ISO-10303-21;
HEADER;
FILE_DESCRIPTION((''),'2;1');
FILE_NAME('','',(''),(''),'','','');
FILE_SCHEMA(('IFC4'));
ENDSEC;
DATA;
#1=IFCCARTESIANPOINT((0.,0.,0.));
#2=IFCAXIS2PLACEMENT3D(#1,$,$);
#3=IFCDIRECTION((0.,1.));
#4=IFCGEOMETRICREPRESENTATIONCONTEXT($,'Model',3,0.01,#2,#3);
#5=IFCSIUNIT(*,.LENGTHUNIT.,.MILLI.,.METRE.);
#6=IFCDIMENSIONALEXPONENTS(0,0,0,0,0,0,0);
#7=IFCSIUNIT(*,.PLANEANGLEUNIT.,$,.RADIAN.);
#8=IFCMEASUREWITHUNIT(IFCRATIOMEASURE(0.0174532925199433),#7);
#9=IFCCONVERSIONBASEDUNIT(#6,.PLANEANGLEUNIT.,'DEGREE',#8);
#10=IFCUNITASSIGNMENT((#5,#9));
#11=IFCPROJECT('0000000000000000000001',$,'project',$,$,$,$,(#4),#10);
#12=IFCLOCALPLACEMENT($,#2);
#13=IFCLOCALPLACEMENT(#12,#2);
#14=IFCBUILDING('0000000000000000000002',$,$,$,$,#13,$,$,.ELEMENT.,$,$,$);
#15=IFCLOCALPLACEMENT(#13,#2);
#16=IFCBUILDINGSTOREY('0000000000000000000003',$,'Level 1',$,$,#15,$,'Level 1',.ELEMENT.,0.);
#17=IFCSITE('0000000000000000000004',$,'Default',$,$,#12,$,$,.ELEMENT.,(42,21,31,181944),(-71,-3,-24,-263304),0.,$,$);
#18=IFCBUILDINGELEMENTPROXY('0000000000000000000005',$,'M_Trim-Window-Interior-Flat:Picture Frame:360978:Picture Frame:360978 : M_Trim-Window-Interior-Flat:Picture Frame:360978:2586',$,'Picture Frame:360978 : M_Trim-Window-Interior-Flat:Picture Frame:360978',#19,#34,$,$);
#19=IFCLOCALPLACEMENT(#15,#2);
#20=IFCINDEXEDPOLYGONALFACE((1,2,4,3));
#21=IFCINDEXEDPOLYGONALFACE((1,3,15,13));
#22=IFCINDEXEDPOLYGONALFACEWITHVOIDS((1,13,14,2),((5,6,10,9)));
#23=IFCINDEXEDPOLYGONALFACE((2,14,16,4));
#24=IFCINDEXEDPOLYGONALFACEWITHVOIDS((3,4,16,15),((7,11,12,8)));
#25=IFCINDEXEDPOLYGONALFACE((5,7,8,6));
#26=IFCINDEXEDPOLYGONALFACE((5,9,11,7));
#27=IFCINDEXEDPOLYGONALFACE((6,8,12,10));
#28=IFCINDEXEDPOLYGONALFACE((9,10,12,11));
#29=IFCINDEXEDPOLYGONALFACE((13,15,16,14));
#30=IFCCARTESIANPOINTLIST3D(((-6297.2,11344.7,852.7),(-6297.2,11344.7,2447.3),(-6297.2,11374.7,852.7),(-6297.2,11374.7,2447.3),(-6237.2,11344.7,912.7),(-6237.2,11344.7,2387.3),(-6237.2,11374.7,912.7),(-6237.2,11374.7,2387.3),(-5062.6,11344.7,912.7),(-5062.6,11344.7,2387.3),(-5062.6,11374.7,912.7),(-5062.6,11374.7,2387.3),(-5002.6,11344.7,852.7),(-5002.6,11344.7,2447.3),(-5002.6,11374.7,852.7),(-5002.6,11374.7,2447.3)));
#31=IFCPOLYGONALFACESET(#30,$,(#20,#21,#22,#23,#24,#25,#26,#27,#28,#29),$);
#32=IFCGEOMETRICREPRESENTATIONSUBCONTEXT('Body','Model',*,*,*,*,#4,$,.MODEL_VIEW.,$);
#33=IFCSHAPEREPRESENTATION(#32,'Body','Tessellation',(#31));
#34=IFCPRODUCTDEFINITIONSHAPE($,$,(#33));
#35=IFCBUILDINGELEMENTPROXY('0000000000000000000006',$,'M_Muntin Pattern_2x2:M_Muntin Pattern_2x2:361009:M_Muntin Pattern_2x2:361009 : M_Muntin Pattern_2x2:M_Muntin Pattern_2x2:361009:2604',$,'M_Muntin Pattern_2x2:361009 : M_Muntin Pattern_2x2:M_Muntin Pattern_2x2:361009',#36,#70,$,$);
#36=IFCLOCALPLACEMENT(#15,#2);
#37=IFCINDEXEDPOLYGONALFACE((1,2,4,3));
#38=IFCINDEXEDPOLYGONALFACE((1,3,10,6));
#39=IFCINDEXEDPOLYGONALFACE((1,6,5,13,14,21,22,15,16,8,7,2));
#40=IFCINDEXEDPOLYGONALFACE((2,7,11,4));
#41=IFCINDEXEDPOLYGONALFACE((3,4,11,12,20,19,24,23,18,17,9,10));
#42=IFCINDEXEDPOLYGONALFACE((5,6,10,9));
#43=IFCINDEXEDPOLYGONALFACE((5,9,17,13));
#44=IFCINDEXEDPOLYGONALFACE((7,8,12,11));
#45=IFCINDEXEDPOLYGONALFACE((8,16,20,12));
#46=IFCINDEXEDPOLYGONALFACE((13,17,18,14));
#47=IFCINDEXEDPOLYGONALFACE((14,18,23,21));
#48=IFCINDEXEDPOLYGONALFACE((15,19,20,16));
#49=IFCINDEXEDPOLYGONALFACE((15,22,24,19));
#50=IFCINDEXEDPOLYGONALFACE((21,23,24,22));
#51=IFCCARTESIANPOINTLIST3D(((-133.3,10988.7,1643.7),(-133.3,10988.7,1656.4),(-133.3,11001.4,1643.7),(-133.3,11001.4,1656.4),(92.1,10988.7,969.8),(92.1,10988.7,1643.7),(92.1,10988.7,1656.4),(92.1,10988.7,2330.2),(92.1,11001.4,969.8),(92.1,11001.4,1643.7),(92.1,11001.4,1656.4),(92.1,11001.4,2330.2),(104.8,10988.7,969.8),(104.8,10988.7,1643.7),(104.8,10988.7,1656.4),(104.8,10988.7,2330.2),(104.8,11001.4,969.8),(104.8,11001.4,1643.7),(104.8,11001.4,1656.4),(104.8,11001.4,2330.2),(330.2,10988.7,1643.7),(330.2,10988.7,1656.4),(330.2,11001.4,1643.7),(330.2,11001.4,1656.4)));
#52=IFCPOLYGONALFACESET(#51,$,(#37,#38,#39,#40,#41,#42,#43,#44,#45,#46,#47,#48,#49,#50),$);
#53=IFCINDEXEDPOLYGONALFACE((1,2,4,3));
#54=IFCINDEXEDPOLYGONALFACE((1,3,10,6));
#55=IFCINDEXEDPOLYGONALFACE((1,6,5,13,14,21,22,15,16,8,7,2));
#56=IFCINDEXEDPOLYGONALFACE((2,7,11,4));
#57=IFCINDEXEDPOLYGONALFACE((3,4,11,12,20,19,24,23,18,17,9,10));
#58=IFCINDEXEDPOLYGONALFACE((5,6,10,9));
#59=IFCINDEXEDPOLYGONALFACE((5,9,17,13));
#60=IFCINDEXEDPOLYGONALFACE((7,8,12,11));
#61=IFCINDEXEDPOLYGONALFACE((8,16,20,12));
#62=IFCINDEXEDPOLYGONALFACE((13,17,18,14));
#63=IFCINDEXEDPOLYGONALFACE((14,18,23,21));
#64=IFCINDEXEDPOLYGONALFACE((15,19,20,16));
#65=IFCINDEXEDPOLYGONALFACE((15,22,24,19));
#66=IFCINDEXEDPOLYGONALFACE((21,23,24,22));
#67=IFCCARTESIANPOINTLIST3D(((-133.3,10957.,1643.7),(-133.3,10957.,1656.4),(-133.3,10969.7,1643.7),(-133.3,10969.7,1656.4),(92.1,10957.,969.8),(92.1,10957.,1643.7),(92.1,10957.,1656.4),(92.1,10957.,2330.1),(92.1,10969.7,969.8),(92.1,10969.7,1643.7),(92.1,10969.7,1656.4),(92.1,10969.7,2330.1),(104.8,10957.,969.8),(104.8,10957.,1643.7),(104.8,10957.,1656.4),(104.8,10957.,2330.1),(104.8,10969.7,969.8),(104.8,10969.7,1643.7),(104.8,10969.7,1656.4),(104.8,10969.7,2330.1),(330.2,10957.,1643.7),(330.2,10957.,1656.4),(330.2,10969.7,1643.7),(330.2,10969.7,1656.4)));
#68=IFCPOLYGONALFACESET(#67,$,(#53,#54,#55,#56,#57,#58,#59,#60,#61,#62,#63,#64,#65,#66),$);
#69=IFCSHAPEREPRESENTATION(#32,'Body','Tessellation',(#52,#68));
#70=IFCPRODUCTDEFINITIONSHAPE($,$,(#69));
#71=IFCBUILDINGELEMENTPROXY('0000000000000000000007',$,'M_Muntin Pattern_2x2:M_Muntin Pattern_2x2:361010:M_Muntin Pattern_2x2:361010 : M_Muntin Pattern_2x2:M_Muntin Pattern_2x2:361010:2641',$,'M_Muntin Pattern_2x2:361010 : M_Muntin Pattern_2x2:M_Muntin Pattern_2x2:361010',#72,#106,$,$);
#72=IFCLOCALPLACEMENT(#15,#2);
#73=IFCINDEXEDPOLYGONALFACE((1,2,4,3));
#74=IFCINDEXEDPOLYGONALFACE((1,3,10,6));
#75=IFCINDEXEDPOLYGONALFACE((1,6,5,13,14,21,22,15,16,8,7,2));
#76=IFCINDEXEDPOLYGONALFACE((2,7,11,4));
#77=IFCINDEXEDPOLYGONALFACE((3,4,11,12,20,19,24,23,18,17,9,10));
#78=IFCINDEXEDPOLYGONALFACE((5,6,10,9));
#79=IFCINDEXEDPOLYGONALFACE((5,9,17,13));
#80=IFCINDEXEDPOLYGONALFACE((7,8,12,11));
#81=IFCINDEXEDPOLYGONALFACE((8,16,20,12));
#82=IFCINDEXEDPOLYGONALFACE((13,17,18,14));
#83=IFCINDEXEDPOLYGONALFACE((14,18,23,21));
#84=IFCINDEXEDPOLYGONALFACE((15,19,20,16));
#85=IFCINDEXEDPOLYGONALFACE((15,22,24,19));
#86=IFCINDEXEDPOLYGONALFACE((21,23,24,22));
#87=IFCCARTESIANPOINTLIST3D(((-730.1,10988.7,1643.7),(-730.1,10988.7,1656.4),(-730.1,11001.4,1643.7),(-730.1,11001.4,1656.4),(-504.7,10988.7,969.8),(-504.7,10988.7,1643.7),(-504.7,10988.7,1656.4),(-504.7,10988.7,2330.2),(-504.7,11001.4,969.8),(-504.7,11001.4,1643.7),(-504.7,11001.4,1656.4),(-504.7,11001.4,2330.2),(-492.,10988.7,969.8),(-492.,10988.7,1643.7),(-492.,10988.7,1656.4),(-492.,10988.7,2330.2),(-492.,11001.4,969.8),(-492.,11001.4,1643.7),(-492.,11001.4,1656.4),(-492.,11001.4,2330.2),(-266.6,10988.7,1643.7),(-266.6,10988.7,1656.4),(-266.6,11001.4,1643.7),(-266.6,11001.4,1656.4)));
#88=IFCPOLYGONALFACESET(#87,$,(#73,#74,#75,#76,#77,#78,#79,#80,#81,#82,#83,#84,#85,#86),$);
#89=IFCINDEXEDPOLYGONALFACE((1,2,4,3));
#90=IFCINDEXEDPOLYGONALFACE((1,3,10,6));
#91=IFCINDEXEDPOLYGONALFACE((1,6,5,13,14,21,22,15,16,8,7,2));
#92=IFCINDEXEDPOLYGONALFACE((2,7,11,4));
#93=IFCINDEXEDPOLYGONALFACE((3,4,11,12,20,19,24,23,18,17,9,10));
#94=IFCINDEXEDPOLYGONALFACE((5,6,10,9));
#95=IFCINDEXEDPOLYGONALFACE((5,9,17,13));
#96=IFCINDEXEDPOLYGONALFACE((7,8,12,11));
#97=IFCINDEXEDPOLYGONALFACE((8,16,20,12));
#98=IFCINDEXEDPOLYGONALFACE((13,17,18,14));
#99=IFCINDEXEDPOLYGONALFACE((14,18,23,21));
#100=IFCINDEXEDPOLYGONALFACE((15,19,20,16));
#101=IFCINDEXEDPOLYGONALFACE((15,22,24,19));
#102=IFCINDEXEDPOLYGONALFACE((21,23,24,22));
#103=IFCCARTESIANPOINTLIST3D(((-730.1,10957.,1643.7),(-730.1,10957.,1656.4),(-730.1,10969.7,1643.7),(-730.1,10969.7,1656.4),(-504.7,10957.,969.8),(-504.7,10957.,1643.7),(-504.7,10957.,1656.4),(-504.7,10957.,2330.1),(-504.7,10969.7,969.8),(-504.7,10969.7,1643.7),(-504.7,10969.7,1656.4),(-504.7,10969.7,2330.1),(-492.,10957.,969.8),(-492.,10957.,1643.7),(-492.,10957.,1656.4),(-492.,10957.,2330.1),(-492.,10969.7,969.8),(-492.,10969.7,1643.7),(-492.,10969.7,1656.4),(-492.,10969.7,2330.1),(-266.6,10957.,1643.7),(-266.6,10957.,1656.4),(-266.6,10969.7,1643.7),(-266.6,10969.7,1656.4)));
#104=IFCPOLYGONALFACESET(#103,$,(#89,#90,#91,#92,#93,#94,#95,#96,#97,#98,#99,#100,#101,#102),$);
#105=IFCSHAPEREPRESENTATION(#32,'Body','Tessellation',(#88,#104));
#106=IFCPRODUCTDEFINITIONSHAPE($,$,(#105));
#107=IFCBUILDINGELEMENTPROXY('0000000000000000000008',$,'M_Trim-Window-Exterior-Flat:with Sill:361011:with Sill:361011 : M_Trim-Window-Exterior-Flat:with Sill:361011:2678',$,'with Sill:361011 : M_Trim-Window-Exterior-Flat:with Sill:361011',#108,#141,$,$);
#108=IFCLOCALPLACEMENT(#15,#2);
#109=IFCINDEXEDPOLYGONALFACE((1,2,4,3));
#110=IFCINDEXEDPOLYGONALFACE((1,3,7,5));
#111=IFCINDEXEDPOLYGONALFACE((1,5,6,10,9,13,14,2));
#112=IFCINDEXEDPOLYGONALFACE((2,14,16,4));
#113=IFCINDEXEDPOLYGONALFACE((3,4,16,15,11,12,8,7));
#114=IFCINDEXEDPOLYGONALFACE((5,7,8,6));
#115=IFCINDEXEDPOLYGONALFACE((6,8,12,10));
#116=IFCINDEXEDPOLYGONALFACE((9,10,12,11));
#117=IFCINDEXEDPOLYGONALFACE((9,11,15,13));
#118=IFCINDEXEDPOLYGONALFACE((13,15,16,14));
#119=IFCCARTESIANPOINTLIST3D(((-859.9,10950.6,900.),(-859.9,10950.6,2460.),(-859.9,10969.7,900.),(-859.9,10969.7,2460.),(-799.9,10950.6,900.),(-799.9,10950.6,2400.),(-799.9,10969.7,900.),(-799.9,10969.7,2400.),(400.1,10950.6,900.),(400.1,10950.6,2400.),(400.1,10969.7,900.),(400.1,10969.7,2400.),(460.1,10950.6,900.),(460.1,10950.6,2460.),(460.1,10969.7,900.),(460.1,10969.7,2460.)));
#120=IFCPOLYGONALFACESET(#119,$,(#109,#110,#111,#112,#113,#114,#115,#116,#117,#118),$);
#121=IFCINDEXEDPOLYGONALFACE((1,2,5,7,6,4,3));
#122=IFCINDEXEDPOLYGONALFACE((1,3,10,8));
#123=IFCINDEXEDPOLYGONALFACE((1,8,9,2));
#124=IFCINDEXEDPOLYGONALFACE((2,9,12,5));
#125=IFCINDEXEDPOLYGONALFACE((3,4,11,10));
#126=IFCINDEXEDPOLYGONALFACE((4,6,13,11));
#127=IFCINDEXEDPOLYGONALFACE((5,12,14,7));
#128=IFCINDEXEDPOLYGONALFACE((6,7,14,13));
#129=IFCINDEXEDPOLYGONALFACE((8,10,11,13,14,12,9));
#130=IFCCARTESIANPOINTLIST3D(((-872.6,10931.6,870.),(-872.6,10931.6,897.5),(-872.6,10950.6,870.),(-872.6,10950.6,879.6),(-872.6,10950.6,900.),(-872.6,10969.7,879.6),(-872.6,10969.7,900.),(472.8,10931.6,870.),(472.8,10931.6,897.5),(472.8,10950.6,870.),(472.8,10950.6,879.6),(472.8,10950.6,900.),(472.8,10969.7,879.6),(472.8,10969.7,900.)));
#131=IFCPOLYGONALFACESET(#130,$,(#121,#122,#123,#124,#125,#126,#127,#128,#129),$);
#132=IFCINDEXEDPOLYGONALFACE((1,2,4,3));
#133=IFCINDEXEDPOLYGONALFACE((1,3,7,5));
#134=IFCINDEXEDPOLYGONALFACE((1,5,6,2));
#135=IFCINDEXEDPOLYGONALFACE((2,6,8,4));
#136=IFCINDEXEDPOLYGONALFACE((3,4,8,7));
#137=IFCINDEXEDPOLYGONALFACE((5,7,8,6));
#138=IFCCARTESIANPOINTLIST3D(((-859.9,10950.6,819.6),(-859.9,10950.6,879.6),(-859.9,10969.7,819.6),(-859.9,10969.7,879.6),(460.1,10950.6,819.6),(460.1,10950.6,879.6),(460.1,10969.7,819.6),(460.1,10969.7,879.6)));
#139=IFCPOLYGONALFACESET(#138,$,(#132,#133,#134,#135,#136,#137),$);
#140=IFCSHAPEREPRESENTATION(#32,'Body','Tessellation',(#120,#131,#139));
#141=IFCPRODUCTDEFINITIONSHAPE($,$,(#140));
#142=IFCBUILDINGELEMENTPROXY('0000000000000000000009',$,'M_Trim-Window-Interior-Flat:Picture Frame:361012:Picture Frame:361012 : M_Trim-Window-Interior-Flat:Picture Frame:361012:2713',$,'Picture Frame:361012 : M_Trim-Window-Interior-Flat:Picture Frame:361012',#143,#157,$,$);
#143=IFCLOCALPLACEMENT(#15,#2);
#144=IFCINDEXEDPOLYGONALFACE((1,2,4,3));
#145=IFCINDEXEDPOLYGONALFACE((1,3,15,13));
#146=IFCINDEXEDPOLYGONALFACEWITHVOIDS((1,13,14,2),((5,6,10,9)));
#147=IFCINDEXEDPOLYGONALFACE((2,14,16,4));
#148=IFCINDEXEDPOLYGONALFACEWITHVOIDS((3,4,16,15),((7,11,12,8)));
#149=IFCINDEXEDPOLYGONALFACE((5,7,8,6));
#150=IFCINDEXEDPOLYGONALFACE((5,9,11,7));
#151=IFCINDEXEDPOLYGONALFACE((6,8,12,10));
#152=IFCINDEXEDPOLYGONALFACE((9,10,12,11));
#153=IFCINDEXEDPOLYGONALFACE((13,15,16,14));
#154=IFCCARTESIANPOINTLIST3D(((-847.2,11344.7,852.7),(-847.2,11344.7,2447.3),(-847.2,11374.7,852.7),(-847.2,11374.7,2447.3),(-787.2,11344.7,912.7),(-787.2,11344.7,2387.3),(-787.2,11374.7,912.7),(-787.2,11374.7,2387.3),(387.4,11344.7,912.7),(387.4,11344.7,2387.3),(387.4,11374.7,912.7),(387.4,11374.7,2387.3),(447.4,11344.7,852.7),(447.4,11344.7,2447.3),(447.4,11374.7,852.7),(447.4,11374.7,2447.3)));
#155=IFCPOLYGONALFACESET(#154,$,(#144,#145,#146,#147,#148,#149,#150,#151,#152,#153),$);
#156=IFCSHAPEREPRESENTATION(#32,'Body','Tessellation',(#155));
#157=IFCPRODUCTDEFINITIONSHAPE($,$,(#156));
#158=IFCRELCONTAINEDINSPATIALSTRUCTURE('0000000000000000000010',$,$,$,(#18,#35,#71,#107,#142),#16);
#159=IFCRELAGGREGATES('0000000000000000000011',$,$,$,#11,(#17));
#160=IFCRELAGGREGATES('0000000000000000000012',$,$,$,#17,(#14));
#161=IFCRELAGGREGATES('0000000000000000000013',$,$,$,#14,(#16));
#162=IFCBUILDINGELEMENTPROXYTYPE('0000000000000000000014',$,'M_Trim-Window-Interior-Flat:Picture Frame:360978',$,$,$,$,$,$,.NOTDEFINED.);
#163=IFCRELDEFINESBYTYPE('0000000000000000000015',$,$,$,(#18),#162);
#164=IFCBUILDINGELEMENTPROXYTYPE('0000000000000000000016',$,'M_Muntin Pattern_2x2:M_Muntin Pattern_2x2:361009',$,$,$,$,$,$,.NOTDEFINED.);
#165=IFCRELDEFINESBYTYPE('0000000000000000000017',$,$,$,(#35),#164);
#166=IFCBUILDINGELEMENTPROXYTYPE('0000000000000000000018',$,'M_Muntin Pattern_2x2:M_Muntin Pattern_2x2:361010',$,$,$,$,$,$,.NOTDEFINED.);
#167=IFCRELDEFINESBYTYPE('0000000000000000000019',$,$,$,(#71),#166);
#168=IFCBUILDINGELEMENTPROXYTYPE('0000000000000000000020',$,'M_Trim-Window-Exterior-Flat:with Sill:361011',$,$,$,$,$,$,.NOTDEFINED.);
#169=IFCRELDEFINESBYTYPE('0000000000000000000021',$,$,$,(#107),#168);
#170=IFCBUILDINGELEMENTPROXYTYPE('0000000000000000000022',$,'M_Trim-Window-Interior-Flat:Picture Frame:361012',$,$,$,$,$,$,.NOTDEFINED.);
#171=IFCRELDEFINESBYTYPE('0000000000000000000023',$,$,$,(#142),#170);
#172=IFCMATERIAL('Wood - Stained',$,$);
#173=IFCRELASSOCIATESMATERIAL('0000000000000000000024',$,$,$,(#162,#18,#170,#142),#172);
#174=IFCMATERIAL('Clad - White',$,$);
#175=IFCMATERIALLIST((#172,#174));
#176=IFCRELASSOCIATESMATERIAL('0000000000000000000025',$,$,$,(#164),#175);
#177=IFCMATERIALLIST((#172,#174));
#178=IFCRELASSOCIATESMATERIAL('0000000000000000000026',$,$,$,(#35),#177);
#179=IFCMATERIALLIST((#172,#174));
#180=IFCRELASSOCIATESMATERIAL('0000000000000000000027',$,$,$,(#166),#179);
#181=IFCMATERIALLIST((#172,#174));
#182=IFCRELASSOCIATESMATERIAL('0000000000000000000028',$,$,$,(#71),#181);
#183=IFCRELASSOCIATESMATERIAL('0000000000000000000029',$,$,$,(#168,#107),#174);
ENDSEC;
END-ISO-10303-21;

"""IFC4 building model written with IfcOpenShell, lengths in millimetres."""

from ifc_helpers import new_model, entity, si_unit, converted_unit, direction, frame, origin, origin_2d_with_axis, place, context, subcontext, project, spatial, polyline, rectangle, outline, extrude, source, transform, mapped, material, material_list, type_object, type_shapes, element, save


model = new_model("IFC4")

# Units and contexts
model_context = context("Model", 3, precision=0.01, world=origin(), true_north=direction((0.0, 1.0)))
body_context = subcontext(model_context, "Body", "Model", "MODEL_VIEW")
ifc_project = project(units=[si_unit("LENGTHUNIT", "METRE", prefix="MILLI"), converted_unit("PLANEANGLEUNIT", "DEGREE", entity("IfcRatioMeasure", 0.0174532925199433), si_unit("PLANEANGLEUNIT", "RADIAN"), dimensions=[0, 0, 0, 0, 0, 0, 0])], contexts=[model_context])

# Site, building, storey
site_placement = place(None, origin())
site = spatial("IfcSite", under=ifc_project, at=site_placement, Name="Default", CompositionType="ELEMENT", RefLatitude=(42, 21, 31, 181944), RefLongitude=(-71, -3, -24, -263304), RefElevation=0.0)
building_placement = place(site_placement, origin())
building = spatial("IfcBuilding", under=site, at=building_placement, CompositionType="ELEMENT")
storey_placement = place(building_placement, origin())
storey = spatial("IfcBuildingStorey", under=building, at=storey_placement, Name="Level 1", LongName="Level 1", CompositionType="ELEMENT", Elevation=0.0)

# Building element proxies
ifc_material_1 = material(Name="Wood - Stained")
ifc_material_2 = material(Name="Clad - White")
building_element_proxy_type_1 = type_object("IfcBuildingElementProxyType", Name="M_Trim-Window-Interior-Flat:Picture Frame:360978", PredefinedType="NOTDEFINED", material=ifc_material_1)
shared_shape_1 = source(origin(), body_context, "Body", "SweptSolid", [
    extrude(outline(polyline([(-797.3, -647.3), (797.3, -647.3), (797.3, 647.3), (-797.3, 647.3), (-797.3, -647.3)]), holes=[polyline([(737.3, 587.3), (737.3, -587.3), (-737.3, -587.3), (-737.3, 587.3), (737.3, 587.3)])]), frame((-5649.9, 11344.7, 1650.0), z_axis=(0.0, 1.0, 0.0), x_axis=(0.0, 0.0, -1.0)), (0.0, 0.0, 1.0), 30.0),
])
type_shapes(building_element_proxy_type_1, [shared_shape_1])
proxy_1_placement = place(storey_placement, origin())
element("IfcBuildingElementProxy", 1, at=proxy_1_placement, inside=storey, type_object=building_element_proxy_type_1, material=ifc_material_1, Name="M_Trim-Window-Interior-Flat:Picture Frame:360978:Picture Frame:360978 : M_Trim-Window-Interior-Flat:Picture Frame:360978:2586", ObjectType="Picture Frame:360978 : M_Trim-Window-Interior-Flat:Picture Frame:360978", context=body_context, shape_type="MappedRepresentation", body=[
    mapped(shared_shape_1, transform((0.0, 0.0, 0.0), scale=1.0)),
])
ifc_material_list_1 = material_list([ifc_material_1, ifc_material_2])
ifc_material_list_2 = material_list([ifc_material_1, ifc_material_2])
building_element_proxy_type_2 = type_object("IfcBuildingElementProxyType", Name="M_Muntin Pattern_2x2:M_Muntin Pattern_2x2:361009", PredefinedType="NOTDEFINED", material=ifc_material_list_2)
shared_shape_2 = source(origin(), body_context, "Body", "SweptSolid", [
    extrude(outline(polyline([(-680.2, 6.4), (-680.2, -6.3), (-6.4, -6.3), (-6.4, -231.7), (6.3, -231.7), (6.3, -6.3), (680.2, -6.3), (680.2, 6.4), (6.3, 6.4), (6.3, 231.7), (-6.4, 231.7), (-6.4, 6.4), (-680.2, 6.4)])), frame((98.5, 10988.7, 1650.0), z_axis=(0.0, -1.0, 0.0), x_axis=(0.0, 0.0, -1.0)), (0.0, 0.0, -1.0), 12.7),
    extrude(outline(polyline([(-680.1, 6.4), (-680.1, -6.3), (-6.4, -6.3), (-6.4, -231.7), (6.3, -231.7), (6.3, -6.3), (680.2, -6.3), (680.2, 6.4), (6.3, 6.4), (6.3, 231.7), (-6.4, 231.7), (-6.4, 6.4), (-680.1, 6.4)])), frame((98.5, 10957.0, 1650.0), z_axis=(0.0, -1.0, 0.0), x_axis=(0.0, 0.0, -1.0)), (0.0, 0.0, -1.0), 12.7),
])
type_shapes(building_element_proxy_type_2, [shared_shape_2])
proxy_2_placement = place(storey_placement, origin())
element("IfcBuildingElementProxy", 2, at=proxy_2_placement, inside=storey, type_object=building_element_proxy_type_2, material=ifc_material_list_1, Name="M_Muntin Pattern_2x2:M_Muntin Pattern_2x2:361009:M_Muntin Pattern_2x2:361009 : M_Muntin Pattern_2x2:M_Muntin Pattern_2x2:361009:2604", ObjectType="M_Muntin Pattern_2x2:361009 : M_Muntin Pattern_2x2:M_Muntin Pattern_2x2:361009", context=body_context, shape_type="MappedRepresentation", body=[
    mapped(shared_shape_2, transform((0.0, 0.0, 0.0), scale=1.0)),
])
ifc_material_list_3 = material_list([ifc_material_1, ifc_material_2])
ifc_material_list_4 = material_list([ifc_material_1, ifc_material_2])
building_element_proxy_type_3 = type_object("IfcBuildingElementProxyType", Name="M_Muntin Pattern_2x2:M_Muntin Pattern_2x2:361010", PredefinedType="NOTDEFINED", material=ifc_material_list_4)
shared_shape_3 = source(origin(), body_context, "Body", "SweptSolid", [
    extrude(outline(polyline([(-6.4, -680.1), (6.3, -680.1), (6.3, -6.4), (231.7, -6.4), (231.7, 6.3), (6.3, 6.3), (6.3, 680.2), (-6.4, 680.2), (-6.4, 6.3), (-231.7, 6.3), (-231.7, -6.4), (-6.4, -6.4), (-6.4, -680.1)])), frame((-498.4, 10988.7, 1650.0), z_axis=(0.0, 1.0, 0.0), x_axis=(1.0, 0.0, 0.0)), (0.0, 0.0, 1.0), 12.7),
    extrude(outline(polyline([(-6.4, -680.1), (6.3, -680.1), (6.3, -6.4), (231.7, -6.4), (231.7, 6.3), (6.3, 6.3), (6.3, 680.2), (-6.4, 680.2), (-6.4, 6.3), (-231.7, 6.3), (-231.7, -6.4), (-6.4, -6.4), (-6.4, -680.1)])), frame((-498.4, 10957.0, 1650.0), z_axis=(0.0, 1.0, 0.0), x_axis=(1.0, 0.0, 0.0)), (0.0, 0.0, 1.0), 12.7),
])
type_shapes(building_element_proxy_type_3, [shared_shape_3])
proxy_3_placement = place(storey_placement, origin())
element("IfcBuildingElementProxy", 3, at=proxy_3_placement, inside=storey, type_object=building_element_proxy_type_3, material=ifc_material_list_3, Name="M_Muntin Pattern_2x2:M_Muntin Pattern_2x2:361010:M_Muntin Pattern_2x2:361010 : M_Muntin Pattern_2x2:M_Muntin Pattern_2x2:361010:2641", ObjectType="M_Muntin Pattern_2x2:361010 : M_Muntin Pattern_2x2:M_Muntin Pattern_2x2:361010", context=body_context, shape_type="MappedRepresentation", body=[
    mapped(shared_shape_3, transform((0.0, 0.0, 0.0), scale=1.0)),
])
building_element_proxy_type_4 = type_object("IfcBuildingElementProxyType", Name="M_Trim-Window-Exterior-Flat:with Sill:361011", PredefinedType="NOTDEFINED", material=ifc_material_2)
shared_shape_4 = source(origin(), body_context, "Body", "SweptSolid", [
    extrude(outline(polyline([(-765.0, -660.0), (795.0, -660.0), (795.0, 660.0), (-765.0, 660.0), (-765.0, 600.0), (735.0, 600.0), (735.0, -600.0), (-765.0, -600.0), (-765.0, -660.0)])), frame((-199.9, 10950.6, 1665.0), z_axis=(0.0, 1.0, 0.0), x_axis=(0.0, 0.0, 1.0)), (0.0, 0.0, 1.0), 19.1),
    extrude(outline(polyline([(-15.2, 0.0), (-15.2, -19.0), (12.3, -19.0), (14.8, 0.0), (14.8, 19.0), (-5.7, 19.0), (-5.7, 0.0), (-15.2, 0.0)])), frame((-872.6, 10950.6, 885.2), z_axis=(-1.0, 0.0, 0.0), x_axis=(0.0, 0.0, 1.0)), (0.0, 0.0, -1.0), 1345.4),
    extrude(rectangle(XDim=19.1, YDim=1320.0, at=origin_2d_with_axis()), frame((-199.9, 10960.1, 819.6), z_axis=(0.0, 0.0, 1.0), x_axis=(0.0, 1.0, 0.0)), (0.0, 0.0, 1.0), 60.0),
])
type_shapes(building_element_proxy_type_4, [shared_shape_4])
proxy_4_placement = place(storey_placement, origin())
element("IfcBuildingElementProxy", 4, at=proxy_4_placement, inside=storey, type_object=building_element_proxy_type_4, material=ifc_material_2, Name="M_Trim-Window-Exterior-Flat:with Sill:361011:with Sill:361011 : M_Trim-Window-Exterior-Flat:with Sill:361011:2678", ObjectType="with Sill:361011 : M_Trim-Window-Exterior-Flat:with Sill:361011", context=body_context, shape_type="MappedRepresentation", body=[
    mapped(shared_shape_4, transform((0.0, 0.0, 0.0), scale=1.0)),
])
building_element_proxy_type_5 = type_object("IfcBuildingElementProxyType", Name="M_Trim-Window-Interior-Flat:Picture Frame:361012", PredefinedType="NOTDEFINED", material=ifc_material_1)
shared_shape_5 = source(origin(), body_context, "Body", "SweptSolid", [
    extrude(outline(polyline([(-797.3, -647.3), (797.3, -647.3), (797.3, 647.3), (-797.3, 647.3), (-797.3, -647.3)]), holes=[polyline([(737.3, 587.3), (737.3, -587.3), (-737.3, -587.3), (-737.3, 587.3), (737.3, 587.3)])]), frame((-199.9, 11344.7, 1650.0), z_axis=(0.0, 1.0, 0.0), x_axis=(0.0, 0.0, -1.0)), (0.0, 0.0, 1.0), 30.0),
])
type_shapes(building_element_proxy_type_5, [shared_shape_5])
proxy_5_placement = place(storey_placement, origin())
element("IfcBuildingElementProxy", 5, at=proxy_5_placement, inside=storey, type_object=building_element_proxy_type_5, material=ifc_material_1, Name="M_Trim-Window-Interior-Flat:Picture Frame:361012:Picture Frame:361012 : M_Trim-Window-Interior-Flat:Picture Frame:361012:2713", ObjectType="Picture Frame:361012 : M_Trim-Window-Interior-Flat:Picture Frame:361012", context=body_context, shape_type="MappedRepresentation", body=[
    mapped(shared_shape_5, transform((0.0, 0.0, 0.0), scale=1.0)),
])

save(model, "model.ifc")
